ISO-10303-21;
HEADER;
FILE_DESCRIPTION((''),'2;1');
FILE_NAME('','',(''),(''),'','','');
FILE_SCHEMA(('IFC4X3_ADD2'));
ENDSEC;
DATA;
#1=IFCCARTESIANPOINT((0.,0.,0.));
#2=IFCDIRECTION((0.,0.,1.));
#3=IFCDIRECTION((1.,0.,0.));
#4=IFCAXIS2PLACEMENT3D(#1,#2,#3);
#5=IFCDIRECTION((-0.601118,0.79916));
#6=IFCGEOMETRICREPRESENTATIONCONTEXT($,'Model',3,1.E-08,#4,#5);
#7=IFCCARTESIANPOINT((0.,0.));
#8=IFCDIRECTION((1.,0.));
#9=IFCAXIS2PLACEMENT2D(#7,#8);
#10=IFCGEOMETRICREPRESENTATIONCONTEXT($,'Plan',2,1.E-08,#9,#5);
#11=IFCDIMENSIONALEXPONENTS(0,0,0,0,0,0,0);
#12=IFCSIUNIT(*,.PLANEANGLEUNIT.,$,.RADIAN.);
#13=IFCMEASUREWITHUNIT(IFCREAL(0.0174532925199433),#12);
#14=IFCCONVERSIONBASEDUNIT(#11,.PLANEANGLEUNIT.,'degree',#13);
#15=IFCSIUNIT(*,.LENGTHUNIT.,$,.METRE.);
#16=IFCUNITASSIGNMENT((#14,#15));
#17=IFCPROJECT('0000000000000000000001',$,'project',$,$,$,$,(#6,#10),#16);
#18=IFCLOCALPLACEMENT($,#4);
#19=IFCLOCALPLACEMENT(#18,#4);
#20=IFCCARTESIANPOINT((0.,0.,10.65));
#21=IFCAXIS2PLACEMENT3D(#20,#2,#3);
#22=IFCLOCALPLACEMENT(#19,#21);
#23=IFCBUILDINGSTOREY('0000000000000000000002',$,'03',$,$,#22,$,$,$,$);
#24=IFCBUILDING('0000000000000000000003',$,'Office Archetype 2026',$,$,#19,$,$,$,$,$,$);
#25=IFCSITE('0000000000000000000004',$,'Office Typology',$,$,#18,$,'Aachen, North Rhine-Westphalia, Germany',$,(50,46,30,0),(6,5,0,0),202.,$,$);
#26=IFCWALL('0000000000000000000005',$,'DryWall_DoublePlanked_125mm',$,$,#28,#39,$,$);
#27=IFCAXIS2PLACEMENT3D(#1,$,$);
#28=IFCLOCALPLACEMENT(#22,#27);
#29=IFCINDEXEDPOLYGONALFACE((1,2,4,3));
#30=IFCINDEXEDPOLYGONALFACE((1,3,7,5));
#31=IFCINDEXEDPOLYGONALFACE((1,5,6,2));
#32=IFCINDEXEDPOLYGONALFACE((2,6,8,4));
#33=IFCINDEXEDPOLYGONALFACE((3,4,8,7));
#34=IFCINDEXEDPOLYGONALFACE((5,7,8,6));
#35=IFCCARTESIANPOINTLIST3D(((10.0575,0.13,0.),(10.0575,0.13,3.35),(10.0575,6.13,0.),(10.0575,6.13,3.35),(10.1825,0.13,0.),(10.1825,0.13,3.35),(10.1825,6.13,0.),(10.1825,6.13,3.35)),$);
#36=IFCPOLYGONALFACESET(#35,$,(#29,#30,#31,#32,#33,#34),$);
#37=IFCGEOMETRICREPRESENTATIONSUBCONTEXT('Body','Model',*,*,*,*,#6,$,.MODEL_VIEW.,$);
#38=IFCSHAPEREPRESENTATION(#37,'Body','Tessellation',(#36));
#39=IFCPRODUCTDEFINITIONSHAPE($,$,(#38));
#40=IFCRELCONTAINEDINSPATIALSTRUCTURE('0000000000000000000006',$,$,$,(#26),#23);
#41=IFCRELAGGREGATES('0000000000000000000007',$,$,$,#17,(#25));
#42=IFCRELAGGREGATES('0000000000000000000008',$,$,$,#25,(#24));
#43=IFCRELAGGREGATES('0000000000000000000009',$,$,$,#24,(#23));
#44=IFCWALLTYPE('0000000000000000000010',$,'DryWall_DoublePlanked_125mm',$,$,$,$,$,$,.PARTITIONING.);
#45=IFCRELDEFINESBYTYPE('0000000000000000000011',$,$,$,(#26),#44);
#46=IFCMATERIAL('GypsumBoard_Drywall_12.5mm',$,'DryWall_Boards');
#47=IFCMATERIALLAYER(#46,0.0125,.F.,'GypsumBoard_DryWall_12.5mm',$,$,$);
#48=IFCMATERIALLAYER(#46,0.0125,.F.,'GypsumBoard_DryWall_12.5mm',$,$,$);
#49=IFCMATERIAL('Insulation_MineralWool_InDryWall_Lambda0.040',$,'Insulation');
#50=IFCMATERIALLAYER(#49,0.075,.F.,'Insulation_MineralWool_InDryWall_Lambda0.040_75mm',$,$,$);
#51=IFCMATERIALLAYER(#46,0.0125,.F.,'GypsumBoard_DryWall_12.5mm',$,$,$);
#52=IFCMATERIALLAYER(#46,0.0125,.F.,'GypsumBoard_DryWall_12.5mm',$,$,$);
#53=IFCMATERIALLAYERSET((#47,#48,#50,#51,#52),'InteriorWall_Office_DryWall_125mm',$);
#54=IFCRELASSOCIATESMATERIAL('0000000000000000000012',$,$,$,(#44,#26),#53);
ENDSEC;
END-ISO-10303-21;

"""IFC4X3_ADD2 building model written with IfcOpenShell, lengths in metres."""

from ifc_helpers import new_model, entity, si_unit, converted_unit, direction, frame, origin_with_axes, origin_2d_with_axis, place, context, subcontext, project, spatial, line, indexed_curve, outline, extrude, material, layer, layer_set, layer_usage, type_object, element, save


model = new_model("IFC4X3_ADD2")

# Units and contexts
model_context = context("Model", 3, precision=1e-08, world=origin_with_axes(), true_north=direction((-0.601118, 0.79916)))
plan_context = context("Plan", 2, precision=1e-08, world=origin_2d_with_axis(), true_north=direction((-0.601118, 0.79916)))
body_context = subcontext(model_context, "Body", "Model", "MODEL_VIEW")
ifc_project = project(units=[converted_unit("PLANEANGLEUNIT", "degree", entity("IfcReal", 0.0174532925199433), si_unit("PLANEANGLEUNIT", "RADIAN"), dimensions=[0, 0, 0, 0, 0, 0, 0]), si_unit("LENGTHUNIT", "METRE")], contexts=[model_context, plan_context])

# Site, building, storey
site_placement = place(None, origin_with_axes())
site = spatial("IfcSite", under=ifc_project, at=site_placement, Name="Office Typology", LongName="Aachen, North Rhine-Westphalia, Germany", RefLatitude=(50, 46, 30, 0), RefLongitude=(6, 5, 0, 0), RefElevation=202.0)
building_placement = place(site_placement, origin_with_axes())
building = spatial("IfcBuilding", under=site, at=building_placement, Name="Office Archetype 2026")
storey_placement = place(building_placement, frame((0.0, 0.0, 10.65), z_axis=(0.0, 0.0, 1.0), x_axis=(1.0, 0.0, 0.0)))
storey = spatial("IfcBuildingStorey", under=building, at=storey_placement, Name="03")

# Wall
ifc_material_1 = material(Name="GypsumBoard_Drywall_12.5mm", Category="DryWall_Boards")
ifc_layer_1 = layer(ifc_material_1, 0.0125, ventilated=False, Name="GypsumBoard_DryWall_12.5mm")
ifc_layer_2 = layer(ifc_material_1, 0.0125, ventilated=False, Name="GypsumBoard_DryWall_12.5mm")
ifc_material_2 = material(Name="Insulation_MineralWool_InDryWall_Lambda0.040", Category="Insulation")
ifc_layer_3 = layer(ifc_material_2, 0.075, ventilated=False, Name="Insulation_MineralWool_InDryWall_Lambda0.040_75mm")
ifc_layer_4 = layer(ifc_material_1, 0.0125, ventilated=False, Name="GypsumBoard_DryWall_12.5mm")
ifc_layer_5 = layer(ifc_material_1, 0.0125, ventilated=False, Name="GypsumBoard_DryWall_12.5mm")
ifc_layer_set_1 = layer_set([ifc_layer_1, ifc_layer_2, ifc_layer_3, ifc_layer_4, ifc_layer_5], Name="InteriorWall_Office_DryWall_125mm")
wall_type_1 = type_object("IfcWallType", Name="DryWall_DoublePlanked_125mm", PredefinedType="PARTITIONING", material=ifc_layer_set_1)
ifc_layer_usage_1 = layer_usage(ifc_layer_set_1, "AXIS2", "POSITIVE", 0.0)
wall_1_placement = place(storey_placement, frame((10.0575, 6.13, 0.0), z_axis=(0.0, 0.0, 1.0), x_axis=(0.0, -1.0, 0.0)))
element("IfcWall", 1, at=wall_1_placement, inside=storey, type_object=wall_type_1, material=ifc_layer_usage_1, Name="DryWall_DoublePlanked_125mm", context=body_context, shape_type="SweptSolid", body=[
    extrude(outline(indexed_curve([(0.0, 0.0), (0.0, 0.125), (6.0, 0.125), (6.0, 0.0)], segments=[line(1, 2, 3, 4, 1)])), origin_with_axes(), (0.0, 0.0, 1.0), 3.35),
])

save(model, "model.ifc")
